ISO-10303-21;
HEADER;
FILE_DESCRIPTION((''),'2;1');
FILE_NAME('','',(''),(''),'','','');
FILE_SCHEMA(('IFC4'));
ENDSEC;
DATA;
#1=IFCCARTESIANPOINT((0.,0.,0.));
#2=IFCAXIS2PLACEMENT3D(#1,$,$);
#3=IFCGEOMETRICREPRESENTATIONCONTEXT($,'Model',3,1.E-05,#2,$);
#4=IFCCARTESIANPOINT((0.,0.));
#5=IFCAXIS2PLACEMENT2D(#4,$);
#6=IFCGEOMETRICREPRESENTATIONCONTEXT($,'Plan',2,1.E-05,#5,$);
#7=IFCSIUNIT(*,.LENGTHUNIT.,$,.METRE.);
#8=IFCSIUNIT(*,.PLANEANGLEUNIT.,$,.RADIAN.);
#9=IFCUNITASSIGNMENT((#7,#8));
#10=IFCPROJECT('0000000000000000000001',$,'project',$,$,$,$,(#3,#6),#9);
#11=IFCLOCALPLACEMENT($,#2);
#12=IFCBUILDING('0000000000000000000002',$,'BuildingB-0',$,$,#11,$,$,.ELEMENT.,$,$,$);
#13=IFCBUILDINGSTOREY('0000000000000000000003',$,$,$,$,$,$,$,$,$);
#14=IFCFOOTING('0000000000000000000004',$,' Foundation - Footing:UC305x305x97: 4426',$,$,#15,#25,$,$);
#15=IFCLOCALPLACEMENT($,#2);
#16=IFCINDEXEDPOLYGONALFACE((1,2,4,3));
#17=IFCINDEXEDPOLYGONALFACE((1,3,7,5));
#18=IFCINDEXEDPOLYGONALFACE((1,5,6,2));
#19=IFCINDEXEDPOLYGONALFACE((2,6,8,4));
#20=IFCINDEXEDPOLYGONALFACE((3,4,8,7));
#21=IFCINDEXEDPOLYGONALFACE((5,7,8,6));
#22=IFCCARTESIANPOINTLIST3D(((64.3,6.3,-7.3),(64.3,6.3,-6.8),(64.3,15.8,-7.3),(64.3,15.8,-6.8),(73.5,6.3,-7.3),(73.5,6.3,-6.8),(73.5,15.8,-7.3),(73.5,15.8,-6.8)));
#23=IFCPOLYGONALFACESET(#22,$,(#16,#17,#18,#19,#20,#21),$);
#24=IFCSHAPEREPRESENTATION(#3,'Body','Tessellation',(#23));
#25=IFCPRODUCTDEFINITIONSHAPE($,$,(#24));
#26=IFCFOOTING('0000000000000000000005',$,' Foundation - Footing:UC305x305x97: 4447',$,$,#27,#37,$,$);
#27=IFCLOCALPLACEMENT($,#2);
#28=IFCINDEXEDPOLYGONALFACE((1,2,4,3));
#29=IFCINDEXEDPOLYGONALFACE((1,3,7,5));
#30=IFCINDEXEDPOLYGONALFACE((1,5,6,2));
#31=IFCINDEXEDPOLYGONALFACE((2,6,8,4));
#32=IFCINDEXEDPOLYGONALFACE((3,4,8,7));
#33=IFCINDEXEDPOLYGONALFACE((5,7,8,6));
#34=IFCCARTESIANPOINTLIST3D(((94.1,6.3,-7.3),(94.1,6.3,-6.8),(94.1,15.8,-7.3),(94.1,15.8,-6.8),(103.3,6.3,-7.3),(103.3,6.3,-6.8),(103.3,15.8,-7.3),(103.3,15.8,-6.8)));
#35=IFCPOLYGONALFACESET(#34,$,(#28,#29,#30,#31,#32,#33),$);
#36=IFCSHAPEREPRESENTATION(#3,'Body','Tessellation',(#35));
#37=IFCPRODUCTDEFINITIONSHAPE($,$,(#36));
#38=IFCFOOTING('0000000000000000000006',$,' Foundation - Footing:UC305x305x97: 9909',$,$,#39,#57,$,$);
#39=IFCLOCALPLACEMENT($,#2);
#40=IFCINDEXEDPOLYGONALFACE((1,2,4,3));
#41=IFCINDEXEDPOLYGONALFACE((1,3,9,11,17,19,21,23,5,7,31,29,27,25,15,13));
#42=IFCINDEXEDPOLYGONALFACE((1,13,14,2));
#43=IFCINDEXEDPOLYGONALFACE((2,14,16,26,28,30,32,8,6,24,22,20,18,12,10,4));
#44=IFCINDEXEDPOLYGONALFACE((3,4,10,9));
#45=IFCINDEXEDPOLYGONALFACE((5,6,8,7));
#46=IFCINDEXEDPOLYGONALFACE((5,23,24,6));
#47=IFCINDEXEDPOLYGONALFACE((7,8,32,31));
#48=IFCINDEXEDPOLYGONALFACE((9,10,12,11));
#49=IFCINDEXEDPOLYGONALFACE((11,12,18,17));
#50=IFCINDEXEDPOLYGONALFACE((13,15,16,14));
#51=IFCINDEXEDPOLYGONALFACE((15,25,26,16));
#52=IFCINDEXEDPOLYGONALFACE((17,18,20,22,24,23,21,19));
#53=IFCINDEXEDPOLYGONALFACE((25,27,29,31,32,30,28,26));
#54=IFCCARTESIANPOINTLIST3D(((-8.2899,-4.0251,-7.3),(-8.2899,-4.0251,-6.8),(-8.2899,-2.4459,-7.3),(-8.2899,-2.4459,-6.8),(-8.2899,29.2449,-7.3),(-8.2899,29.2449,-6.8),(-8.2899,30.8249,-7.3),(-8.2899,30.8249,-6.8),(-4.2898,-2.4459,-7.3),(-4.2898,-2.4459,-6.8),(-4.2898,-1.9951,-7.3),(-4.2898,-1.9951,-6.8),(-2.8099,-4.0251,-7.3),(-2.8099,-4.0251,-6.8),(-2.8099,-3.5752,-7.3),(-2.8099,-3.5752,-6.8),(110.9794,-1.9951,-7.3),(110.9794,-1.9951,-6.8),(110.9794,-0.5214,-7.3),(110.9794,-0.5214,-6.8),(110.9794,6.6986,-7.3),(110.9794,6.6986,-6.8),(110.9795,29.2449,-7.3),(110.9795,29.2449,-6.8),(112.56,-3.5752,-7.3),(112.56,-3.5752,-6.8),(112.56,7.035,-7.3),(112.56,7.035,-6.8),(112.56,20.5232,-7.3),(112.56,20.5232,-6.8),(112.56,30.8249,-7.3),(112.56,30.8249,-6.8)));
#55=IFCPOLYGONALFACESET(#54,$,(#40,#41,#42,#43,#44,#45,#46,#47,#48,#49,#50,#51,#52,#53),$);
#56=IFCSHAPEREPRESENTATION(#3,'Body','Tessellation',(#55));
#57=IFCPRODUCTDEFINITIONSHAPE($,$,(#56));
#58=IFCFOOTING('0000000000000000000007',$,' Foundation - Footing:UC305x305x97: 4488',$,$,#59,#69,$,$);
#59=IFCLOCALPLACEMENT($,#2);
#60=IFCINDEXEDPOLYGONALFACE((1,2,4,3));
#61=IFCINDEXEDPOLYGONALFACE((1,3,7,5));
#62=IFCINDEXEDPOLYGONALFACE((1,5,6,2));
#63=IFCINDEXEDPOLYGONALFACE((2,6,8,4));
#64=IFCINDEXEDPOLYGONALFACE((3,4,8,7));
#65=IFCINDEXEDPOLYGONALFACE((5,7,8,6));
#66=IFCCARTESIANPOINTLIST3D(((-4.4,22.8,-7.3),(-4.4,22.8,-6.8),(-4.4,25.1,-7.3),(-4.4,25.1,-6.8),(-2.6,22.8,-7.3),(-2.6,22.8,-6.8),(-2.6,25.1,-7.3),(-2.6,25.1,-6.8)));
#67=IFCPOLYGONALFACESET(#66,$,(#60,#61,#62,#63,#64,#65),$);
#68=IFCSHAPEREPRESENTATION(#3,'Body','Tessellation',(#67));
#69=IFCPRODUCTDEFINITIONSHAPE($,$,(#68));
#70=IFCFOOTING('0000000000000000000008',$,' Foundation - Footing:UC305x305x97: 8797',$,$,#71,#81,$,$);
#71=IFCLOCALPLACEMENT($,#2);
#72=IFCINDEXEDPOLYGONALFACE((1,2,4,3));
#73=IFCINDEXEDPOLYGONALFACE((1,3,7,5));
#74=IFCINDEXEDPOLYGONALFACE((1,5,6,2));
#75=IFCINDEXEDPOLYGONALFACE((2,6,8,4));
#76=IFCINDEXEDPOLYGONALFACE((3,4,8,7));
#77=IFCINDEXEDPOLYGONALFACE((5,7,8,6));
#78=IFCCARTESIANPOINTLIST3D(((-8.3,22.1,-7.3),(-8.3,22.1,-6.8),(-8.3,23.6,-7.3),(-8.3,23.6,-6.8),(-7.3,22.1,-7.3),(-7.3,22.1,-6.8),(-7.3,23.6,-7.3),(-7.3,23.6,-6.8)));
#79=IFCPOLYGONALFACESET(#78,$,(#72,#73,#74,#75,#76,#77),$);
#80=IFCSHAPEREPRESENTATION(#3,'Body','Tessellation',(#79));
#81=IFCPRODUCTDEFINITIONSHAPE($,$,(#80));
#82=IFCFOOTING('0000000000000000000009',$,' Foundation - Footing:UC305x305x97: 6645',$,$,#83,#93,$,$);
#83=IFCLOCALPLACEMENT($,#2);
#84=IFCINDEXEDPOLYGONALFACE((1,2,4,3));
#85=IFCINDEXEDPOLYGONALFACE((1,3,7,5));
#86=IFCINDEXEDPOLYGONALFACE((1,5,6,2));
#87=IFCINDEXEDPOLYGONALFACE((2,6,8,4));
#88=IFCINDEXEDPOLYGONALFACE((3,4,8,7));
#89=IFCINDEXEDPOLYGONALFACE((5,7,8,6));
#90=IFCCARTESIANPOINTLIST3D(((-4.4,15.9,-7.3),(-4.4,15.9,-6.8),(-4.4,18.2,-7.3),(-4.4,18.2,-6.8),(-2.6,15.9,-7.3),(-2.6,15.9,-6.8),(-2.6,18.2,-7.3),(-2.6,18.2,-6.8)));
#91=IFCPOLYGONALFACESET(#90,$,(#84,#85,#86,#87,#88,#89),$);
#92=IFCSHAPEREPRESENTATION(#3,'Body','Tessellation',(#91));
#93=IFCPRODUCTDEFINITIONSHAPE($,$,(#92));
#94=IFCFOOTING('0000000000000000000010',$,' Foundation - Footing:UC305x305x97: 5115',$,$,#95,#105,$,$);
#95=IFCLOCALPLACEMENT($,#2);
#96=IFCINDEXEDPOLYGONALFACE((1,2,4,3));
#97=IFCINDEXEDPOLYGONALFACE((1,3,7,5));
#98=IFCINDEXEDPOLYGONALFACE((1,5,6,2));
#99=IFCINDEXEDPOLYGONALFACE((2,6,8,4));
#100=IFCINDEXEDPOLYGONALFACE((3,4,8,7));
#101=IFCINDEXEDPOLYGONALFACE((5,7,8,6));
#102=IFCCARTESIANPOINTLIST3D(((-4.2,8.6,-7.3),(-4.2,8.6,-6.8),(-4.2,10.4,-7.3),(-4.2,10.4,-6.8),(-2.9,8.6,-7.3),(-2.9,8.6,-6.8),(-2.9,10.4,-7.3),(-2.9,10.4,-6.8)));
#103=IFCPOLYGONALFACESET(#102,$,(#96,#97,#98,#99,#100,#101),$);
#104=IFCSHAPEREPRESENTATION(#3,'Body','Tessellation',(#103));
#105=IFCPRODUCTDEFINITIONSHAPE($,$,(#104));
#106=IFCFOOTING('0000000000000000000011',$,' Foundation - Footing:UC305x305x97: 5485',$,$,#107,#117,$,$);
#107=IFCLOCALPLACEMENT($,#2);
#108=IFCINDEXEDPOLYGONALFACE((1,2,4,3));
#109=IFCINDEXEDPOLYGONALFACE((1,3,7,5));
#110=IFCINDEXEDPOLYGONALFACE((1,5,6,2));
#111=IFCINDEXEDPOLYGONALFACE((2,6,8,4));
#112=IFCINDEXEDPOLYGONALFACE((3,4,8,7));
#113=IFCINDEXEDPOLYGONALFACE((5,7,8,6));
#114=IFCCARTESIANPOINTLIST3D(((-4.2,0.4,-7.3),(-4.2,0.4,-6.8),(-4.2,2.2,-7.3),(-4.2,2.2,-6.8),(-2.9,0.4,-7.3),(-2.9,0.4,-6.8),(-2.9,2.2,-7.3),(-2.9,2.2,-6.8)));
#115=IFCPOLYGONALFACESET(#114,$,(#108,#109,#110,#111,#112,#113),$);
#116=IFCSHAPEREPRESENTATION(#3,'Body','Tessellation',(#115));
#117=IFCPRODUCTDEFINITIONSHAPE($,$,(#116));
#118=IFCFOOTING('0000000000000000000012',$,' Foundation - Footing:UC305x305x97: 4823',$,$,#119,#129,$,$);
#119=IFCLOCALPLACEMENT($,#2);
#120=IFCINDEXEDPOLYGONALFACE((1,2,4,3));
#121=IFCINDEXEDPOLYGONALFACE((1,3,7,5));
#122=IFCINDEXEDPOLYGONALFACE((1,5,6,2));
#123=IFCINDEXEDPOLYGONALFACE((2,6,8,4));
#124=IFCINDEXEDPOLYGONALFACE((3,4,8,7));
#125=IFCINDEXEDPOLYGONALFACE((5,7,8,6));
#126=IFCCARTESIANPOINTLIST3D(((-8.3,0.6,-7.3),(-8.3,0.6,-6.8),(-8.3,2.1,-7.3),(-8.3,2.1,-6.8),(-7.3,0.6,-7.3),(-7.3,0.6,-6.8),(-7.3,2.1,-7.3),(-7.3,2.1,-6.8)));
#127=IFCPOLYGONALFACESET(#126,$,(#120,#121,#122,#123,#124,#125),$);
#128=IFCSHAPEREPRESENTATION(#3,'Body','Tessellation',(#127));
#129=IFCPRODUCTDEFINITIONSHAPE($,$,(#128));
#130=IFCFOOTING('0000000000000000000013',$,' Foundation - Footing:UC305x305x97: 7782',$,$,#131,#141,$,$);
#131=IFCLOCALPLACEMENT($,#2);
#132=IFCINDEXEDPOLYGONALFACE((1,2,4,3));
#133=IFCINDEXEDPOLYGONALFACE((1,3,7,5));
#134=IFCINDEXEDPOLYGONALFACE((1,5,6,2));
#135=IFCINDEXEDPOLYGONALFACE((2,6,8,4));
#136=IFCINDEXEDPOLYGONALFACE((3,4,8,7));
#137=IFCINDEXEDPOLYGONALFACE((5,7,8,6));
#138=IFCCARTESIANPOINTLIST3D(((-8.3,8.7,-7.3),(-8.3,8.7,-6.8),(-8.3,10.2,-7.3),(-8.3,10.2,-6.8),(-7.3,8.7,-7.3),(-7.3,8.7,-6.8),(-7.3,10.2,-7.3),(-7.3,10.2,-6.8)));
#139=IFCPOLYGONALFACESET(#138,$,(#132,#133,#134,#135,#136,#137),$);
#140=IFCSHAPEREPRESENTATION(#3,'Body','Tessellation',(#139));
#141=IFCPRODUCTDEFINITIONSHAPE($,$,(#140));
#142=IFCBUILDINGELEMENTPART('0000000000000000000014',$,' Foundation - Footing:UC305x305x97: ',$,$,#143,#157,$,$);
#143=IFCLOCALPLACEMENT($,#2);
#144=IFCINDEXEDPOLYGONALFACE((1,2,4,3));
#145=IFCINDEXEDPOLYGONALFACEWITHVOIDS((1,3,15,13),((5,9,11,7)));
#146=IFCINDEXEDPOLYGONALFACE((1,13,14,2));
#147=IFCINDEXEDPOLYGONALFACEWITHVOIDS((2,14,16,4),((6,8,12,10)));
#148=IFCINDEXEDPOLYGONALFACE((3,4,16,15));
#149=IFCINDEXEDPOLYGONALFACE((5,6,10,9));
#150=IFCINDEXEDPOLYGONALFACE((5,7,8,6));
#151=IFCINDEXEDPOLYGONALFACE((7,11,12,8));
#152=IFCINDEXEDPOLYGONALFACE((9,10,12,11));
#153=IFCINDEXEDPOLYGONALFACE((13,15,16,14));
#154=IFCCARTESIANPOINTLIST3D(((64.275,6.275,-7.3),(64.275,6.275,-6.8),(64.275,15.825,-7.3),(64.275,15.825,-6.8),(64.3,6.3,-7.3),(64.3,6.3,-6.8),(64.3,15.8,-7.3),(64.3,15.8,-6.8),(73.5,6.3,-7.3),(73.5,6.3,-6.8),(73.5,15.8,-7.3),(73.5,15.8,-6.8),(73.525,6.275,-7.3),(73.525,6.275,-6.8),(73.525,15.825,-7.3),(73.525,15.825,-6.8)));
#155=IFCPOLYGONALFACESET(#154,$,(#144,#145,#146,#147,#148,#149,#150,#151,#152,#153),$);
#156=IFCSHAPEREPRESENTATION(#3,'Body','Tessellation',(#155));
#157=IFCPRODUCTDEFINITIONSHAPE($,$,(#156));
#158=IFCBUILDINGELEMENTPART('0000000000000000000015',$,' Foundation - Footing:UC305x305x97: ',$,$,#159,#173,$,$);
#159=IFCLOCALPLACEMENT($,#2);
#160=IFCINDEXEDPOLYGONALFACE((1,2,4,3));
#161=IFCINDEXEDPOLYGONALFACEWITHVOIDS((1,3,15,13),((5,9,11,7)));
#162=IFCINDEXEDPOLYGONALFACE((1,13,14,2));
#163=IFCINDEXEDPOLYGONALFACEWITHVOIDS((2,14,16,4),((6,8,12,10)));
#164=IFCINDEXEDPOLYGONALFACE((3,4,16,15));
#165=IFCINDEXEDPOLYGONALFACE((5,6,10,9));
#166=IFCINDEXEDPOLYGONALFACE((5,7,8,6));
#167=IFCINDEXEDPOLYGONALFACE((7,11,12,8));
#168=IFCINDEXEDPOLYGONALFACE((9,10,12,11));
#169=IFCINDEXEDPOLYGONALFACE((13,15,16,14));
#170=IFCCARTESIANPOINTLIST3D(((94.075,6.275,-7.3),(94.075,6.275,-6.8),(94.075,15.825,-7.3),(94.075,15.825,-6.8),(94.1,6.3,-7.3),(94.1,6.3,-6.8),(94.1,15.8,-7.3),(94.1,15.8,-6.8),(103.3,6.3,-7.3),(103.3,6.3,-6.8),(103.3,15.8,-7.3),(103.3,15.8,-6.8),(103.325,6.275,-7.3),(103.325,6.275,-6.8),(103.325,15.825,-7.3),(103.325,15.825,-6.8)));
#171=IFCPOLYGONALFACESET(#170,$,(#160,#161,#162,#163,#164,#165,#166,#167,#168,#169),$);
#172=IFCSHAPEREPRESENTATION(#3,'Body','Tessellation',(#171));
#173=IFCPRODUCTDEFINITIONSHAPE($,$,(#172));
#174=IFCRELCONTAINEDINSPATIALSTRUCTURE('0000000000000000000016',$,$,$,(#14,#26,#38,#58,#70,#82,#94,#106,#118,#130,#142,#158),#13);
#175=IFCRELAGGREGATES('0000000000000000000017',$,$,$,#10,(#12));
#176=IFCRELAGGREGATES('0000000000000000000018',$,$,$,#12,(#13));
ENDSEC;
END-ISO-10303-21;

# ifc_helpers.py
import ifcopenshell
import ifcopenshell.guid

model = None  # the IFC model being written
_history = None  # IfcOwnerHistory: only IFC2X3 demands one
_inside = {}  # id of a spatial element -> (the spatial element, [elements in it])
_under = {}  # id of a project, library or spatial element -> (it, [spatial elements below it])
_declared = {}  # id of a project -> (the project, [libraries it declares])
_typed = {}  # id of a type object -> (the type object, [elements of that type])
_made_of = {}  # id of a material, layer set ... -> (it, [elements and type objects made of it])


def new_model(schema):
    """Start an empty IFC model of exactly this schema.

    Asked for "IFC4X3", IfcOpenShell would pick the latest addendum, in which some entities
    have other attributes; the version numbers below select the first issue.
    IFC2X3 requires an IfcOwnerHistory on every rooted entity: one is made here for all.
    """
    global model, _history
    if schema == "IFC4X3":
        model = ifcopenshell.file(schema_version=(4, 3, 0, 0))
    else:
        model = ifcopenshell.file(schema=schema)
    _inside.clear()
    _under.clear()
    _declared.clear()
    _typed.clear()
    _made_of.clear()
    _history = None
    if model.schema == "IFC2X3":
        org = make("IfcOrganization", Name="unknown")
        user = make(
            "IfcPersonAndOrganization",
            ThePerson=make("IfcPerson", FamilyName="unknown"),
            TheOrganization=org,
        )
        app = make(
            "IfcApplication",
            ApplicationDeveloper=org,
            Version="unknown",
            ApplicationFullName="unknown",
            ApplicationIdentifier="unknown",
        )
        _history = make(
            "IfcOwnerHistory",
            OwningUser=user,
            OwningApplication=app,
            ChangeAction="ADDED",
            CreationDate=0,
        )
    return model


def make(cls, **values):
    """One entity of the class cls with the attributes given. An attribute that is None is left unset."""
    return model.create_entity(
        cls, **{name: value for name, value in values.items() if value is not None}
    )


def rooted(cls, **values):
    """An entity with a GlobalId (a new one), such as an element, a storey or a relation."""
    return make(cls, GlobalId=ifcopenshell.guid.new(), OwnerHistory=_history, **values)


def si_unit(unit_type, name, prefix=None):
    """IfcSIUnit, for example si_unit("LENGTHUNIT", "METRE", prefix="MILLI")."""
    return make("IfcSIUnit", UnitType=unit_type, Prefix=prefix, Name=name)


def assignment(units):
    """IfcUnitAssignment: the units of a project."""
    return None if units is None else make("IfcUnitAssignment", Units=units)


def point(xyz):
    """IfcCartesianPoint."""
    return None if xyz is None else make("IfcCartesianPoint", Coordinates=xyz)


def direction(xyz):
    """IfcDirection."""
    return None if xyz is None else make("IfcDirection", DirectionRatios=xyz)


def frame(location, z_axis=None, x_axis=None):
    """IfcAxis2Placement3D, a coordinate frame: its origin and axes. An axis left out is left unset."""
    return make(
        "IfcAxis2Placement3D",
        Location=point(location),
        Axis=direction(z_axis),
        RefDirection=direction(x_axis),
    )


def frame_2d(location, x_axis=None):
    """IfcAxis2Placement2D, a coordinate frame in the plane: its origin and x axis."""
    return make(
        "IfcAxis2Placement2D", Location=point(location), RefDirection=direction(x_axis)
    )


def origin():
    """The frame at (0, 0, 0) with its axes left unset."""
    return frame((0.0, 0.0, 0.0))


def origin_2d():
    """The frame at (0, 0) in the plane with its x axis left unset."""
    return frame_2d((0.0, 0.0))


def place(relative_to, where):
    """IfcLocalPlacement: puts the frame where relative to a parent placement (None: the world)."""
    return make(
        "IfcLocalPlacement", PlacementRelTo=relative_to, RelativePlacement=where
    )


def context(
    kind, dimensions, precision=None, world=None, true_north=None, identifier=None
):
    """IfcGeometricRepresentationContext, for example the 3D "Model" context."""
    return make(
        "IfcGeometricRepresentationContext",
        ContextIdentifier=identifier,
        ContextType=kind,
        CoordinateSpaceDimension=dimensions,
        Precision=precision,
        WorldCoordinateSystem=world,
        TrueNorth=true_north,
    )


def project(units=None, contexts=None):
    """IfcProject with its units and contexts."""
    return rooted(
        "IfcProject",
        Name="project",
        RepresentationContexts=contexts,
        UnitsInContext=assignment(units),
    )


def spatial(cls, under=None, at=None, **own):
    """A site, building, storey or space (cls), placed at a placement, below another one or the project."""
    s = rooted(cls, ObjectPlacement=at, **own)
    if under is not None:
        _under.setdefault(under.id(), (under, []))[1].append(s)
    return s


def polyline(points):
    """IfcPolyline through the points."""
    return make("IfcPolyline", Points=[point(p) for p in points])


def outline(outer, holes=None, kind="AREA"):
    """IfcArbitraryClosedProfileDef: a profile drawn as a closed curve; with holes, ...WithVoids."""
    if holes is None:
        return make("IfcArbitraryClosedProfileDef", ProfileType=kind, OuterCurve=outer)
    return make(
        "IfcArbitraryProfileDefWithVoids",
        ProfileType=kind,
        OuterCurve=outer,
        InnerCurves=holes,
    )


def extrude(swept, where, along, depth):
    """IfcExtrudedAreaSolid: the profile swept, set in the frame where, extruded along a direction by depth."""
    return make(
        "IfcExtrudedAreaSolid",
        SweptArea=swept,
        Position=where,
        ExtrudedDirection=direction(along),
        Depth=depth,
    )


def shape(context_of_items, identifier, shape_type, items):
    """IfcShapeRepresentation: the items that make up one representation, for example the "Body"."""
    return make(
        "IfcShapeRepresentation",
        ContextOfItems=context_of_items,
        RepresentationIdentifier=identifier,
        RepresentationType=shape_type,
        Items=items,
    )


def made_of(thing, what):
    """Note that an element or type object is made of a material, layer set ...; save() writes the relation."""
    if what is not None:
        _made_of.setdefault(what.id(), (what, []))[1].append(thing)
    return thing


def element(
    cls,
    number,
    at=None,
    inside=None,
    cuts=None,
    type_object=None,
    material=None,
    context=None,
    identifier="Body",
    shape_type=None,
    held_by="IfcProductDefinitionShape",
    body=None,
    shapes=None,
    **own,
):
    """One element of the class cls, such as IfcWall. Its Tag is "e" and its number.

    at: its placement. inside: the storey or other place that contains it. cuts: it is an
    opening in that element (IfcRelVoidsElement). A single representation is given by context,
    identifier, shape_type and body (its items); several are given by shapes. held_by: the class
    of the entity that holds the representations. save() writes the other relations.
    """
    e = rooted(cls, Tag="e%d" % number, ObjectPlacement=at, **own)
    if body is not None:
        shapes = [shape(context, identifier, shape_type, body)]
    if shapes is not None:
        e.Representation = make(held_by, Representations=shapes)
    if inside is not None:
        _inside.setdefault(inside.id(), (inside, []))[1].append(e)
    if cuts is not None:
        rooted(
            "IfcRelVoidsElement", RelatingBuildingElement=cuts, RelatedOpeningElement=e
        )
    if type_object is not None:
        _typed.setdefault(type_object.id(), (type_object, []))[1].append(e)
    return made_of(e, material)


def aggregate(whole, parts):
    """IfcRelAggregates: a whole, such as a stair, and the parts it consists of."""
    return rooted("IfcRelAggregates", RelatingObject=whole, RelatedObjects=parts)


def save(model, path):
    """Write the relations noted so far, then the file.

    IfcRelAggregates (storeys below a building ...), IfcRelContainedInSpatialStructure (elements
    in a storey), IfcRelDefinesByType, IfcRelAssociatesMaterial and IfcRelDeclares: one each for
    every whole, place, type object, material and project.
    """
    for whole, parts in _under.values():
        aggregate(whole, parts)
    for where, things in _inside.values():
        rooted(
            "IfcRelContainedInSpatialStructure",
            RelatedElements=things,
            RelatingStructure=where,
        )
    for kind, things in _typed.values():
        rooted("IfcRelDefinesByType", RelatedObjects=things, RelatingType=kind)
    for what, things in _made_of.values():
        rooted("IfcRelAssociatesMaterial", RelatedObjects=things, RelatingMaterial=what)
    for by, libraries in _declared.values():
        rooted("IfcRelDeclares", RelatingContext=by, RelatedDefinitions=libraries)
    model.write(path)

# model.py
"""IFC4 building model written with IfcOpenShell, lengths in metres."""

from ifc_helpers import new_model, si_unit, origin, origin_2d, place, context, project, spatial, polyline, outline, extrude, element, save


model = new_model("IFC4")

# Units and contexts
model_context = context("Model", 3, precision=1e-05, world=origin())
plan_context = context("Plan", 2, precision=1e-05, world=origin_2d())
ifc_project = project(units=[si_unit("LENGTHUNIT", "METRE"), si_unit("PLANEANGLEUNIT", "RADIAN")], contexts=[model_context, plan_context])

# Building, storey
building_placement = place(None, origin())
building = spatial("IfcBuilding", under=ifc_project, at=building_placement, Name="BuildingB-0", CompositionType="ELEMENT")
storey = spatial("IfcBuildingStorey", under=building)

# Footings
element("IfcFooting", 1, inside=storey, Name=" Foundation - Footing:UC305x305x97: 4426", context=model_context, shape_type="SweptSolid", body=[
    extrude(outline(polyline([(64.3, 15.8, -7.3), (73.5, 15.8, -7.3), (73.5, 6.3, -7.3), (64.3, 6.3, -7.3), (64.3, 15.8, -7.3)])), None, (0.0, 0.0, 1.0), 0.5),
])
element("IfcFooting", 2, inside=storey, Name=" Foundation - Footing:UC305x305x97: 4447", context=model_context, shape_type="SweptSolid", body=[
    extrude(outline(polyline([(94.1, 15.8, -7.3), (103.3, 15.8, -7.3), (103.3, 6.3, -7.3), (94.1, 6.3, -7.3), (94.1, 15.8, -7.3)])), None, (0.0, 0.0, 1.0), 0.5),
])
element("IfcFooting", 3, inside=storey, Name=" Foundation - Footing:UC305x305x97: 9909", context=model_context, shape_type="SweptSolid", body=[
    extrude(outline(polyline([(-8.2899, 30.8249, -7.3), (112.56, 30.8249, -7.3), (112.56, 20.5232, -7.3), (112.56, 7.035, -7.3), (112.56, -3.5752, -7.3), (-2.8099, -3.5752, -7.3), (-2.8099, -4.0251, -7.3), (-8.2899, -4.0251, -7.3), (-8.2899, -2.4459, -7.3), (-4.2898, -2.4459, -7.3), (-4.2898, -1.9951, -7.3), (110.9794, -1.9951, -7.3), (110.9794, -0.5214, -7.3), (110.9794, 6.6986, -7.3), (110.9795, 29.2449, -7.3), (-8.2899, 29.2449, -7.3), (-8.2899, 30.8249, -7.3)])), None, (0.0, 0.0, 1.0), 0.5),
])
element("IfcFooting", 4, inside=storey, Name=" Foundation - Footing:UC305x305x97: 4488", context=model_context, shape_type="SweptSolid", body=[
    extrude(outline(polyline([(-4.4, 25.1, -7.3), (-2.6, 25.1, -7.3), (-2.6, 22.8, -7.3), (-4.4, 22.8, -7.3), (-4.4, 25.1, -7.3)])), None, (0.0, 0.0, 1.0), 0.5),
])
element("IfcFooting", 5, inside=storey, Name=" Foundation - Footing:UC305x305x97: 8797", context=model_context, shape_type="SweptSolid", body=[
    extrude(outline(polyline([(-7.3, 23.6, -7.3), (-8.3, 23.6, -7.3), (-8.3, 22.1, -7.3), (-7.3, 22.1, -7.3), (-7.3, 23.6, -7.3)])), None, (0.0, 0.0, 1.0), 0.5),
])
element("IfcFooting", 6, inside=storey, Name=" Foundation - Footing:UC305x305x97: 6645", context=model_context, shape_type="SweptSolid", body=[
    extrude(outline(polyline([(-2.6, 18.2, -7.3), (-4.4, 18.2, -7.3), (-4.4, 15.9, -7.3), (-2.6, 15.9, -7.3), (-2.6, 18.2, -7.3)])), None, (0.0, 0.0, 1.0), 0.5),
])
element("IfcFooting", 7, inside=storey, Name=" Foundation - Footing:UC305x305x97: 5115", context=model_context, shape_type="SweptSolid", body=[
    extrude(outline(polyline([(-2.9, 10.4, -7.3), (-4.2, 10.4, -7.3), (-4.2, 8.6, -7.3), (-2.9, 8.6, -7.3), (-2.9, 10.4, -7.3)])), None, (0.0, 0.0, 1.0), 0.5),
])
element("IfcFooting", 8, inside=storey, Name=" Foundation - Footing:UC305x305x97: 5485", context=model_context, shape_type="SweptSolid", body=[
    extrude(outline(polyline([(-2.9, 2.2, -7.3), (-4.2, 2.2, -7.3), (-4.2, 0.4, -7.3), (-2.9, 0.4, -7.3), (-2.9, 2.2, -7.3)])), None, (0.0, 0.0, 1.0), 0.5),
])
element("IfcFooting", 9, inside=storey, Name=" Foundation - Footing:UC305x305x97: 4823", context=model_context, shape_type="SweptSolid", body=[
    extrude(outline(polyline([(-7.3, 2.1, -7.3), (-8.3, 2.1, -7.3), (-8.3, 0.6, -7.3), (-7.3, 0.6, -7.3), (-7.3, 2.1, -7.3)])), None, (0.0, 0.0, 1.0), 0.5),
])
element("IfcFooting", 10, inside=storey, Name=" Foundation - Footing:UC305x305x97: 7782", context=model_context, shape_type="SweptSolid", body=[
    extrude(outline(polyline([(-7.3, 10.2, -7.3), (-8.3, 10.2, -7.3), (-8.3, 8.7, -7.3), (-7.3, 8.7, -7.3), (-7.3, 10.2, -7.3)])), None, (0.0, 0.0, 1.0), 0.5),
])

# Building element parts, openings
building_element_part_1 = element("IfcBuildingElementPart", 11, inside=storey, Name=" Foundation - Footing:UC305x305x97: ", context=model_context, shape_type="SweptSolid", body=[
    extrude(outline(polyline([(64.275, 15.825, -7.3), (73.525, 15.825, -7.3), (73.525, 6.275, -7.3), (64.275, 6.275, -7.3), (64.275, 15.825, -7.3)])), None, (0.0, 0.0, 1.0), 0.5),
])
element("IfcOpeningElement", 12, inside=storey, cuts=building_element_part_1, context=model_context, shape_type="SweptSolid", body=[
    extrude(outline(polyline([(64.3, 15.8, -7.3), (73.5, 15.8, -7.3), (73.5, 6.3, -7.3), (64.3, 6.3, -7.3), (64.3, 15.8, -7.3)])), None, (0.0, 0.0, 1.0), 0.5),
])
building_element_part_2 = element("IfcBuildingElementPart", 13, inside=storey, Name=" Foundation - Footing:UC305x305x97: ", context=model_context, shape_type="SweptSolid", body=[
    extrude(outline(polyline([(94.075, 15.825, -7.3), (103.325, 15.825, -7.3), (103.325, 6.275, -7.3), (94.075, 6.275, -7.3), (94.075, 15.825, -7.3)])), None, (0.0, 0.0, 1.0), 0.5),
])
element("IfcOpeningElement", 14, inside=storey, cuts=building_element_part_2, context=model_context, shape_type="SweptSolid", body=[
    extrude(outline(polyline([(94.1, 15.8, -7.3), (103.3, 15.8, -7.3), (103.3, 6.3, -7.3), (94.1, 6.3, -7.3), (94.1, 15.8, -7.3)])), None, (0.0, 0.0, 1.0), 0.5),
])

save(model, "model.ifc")
